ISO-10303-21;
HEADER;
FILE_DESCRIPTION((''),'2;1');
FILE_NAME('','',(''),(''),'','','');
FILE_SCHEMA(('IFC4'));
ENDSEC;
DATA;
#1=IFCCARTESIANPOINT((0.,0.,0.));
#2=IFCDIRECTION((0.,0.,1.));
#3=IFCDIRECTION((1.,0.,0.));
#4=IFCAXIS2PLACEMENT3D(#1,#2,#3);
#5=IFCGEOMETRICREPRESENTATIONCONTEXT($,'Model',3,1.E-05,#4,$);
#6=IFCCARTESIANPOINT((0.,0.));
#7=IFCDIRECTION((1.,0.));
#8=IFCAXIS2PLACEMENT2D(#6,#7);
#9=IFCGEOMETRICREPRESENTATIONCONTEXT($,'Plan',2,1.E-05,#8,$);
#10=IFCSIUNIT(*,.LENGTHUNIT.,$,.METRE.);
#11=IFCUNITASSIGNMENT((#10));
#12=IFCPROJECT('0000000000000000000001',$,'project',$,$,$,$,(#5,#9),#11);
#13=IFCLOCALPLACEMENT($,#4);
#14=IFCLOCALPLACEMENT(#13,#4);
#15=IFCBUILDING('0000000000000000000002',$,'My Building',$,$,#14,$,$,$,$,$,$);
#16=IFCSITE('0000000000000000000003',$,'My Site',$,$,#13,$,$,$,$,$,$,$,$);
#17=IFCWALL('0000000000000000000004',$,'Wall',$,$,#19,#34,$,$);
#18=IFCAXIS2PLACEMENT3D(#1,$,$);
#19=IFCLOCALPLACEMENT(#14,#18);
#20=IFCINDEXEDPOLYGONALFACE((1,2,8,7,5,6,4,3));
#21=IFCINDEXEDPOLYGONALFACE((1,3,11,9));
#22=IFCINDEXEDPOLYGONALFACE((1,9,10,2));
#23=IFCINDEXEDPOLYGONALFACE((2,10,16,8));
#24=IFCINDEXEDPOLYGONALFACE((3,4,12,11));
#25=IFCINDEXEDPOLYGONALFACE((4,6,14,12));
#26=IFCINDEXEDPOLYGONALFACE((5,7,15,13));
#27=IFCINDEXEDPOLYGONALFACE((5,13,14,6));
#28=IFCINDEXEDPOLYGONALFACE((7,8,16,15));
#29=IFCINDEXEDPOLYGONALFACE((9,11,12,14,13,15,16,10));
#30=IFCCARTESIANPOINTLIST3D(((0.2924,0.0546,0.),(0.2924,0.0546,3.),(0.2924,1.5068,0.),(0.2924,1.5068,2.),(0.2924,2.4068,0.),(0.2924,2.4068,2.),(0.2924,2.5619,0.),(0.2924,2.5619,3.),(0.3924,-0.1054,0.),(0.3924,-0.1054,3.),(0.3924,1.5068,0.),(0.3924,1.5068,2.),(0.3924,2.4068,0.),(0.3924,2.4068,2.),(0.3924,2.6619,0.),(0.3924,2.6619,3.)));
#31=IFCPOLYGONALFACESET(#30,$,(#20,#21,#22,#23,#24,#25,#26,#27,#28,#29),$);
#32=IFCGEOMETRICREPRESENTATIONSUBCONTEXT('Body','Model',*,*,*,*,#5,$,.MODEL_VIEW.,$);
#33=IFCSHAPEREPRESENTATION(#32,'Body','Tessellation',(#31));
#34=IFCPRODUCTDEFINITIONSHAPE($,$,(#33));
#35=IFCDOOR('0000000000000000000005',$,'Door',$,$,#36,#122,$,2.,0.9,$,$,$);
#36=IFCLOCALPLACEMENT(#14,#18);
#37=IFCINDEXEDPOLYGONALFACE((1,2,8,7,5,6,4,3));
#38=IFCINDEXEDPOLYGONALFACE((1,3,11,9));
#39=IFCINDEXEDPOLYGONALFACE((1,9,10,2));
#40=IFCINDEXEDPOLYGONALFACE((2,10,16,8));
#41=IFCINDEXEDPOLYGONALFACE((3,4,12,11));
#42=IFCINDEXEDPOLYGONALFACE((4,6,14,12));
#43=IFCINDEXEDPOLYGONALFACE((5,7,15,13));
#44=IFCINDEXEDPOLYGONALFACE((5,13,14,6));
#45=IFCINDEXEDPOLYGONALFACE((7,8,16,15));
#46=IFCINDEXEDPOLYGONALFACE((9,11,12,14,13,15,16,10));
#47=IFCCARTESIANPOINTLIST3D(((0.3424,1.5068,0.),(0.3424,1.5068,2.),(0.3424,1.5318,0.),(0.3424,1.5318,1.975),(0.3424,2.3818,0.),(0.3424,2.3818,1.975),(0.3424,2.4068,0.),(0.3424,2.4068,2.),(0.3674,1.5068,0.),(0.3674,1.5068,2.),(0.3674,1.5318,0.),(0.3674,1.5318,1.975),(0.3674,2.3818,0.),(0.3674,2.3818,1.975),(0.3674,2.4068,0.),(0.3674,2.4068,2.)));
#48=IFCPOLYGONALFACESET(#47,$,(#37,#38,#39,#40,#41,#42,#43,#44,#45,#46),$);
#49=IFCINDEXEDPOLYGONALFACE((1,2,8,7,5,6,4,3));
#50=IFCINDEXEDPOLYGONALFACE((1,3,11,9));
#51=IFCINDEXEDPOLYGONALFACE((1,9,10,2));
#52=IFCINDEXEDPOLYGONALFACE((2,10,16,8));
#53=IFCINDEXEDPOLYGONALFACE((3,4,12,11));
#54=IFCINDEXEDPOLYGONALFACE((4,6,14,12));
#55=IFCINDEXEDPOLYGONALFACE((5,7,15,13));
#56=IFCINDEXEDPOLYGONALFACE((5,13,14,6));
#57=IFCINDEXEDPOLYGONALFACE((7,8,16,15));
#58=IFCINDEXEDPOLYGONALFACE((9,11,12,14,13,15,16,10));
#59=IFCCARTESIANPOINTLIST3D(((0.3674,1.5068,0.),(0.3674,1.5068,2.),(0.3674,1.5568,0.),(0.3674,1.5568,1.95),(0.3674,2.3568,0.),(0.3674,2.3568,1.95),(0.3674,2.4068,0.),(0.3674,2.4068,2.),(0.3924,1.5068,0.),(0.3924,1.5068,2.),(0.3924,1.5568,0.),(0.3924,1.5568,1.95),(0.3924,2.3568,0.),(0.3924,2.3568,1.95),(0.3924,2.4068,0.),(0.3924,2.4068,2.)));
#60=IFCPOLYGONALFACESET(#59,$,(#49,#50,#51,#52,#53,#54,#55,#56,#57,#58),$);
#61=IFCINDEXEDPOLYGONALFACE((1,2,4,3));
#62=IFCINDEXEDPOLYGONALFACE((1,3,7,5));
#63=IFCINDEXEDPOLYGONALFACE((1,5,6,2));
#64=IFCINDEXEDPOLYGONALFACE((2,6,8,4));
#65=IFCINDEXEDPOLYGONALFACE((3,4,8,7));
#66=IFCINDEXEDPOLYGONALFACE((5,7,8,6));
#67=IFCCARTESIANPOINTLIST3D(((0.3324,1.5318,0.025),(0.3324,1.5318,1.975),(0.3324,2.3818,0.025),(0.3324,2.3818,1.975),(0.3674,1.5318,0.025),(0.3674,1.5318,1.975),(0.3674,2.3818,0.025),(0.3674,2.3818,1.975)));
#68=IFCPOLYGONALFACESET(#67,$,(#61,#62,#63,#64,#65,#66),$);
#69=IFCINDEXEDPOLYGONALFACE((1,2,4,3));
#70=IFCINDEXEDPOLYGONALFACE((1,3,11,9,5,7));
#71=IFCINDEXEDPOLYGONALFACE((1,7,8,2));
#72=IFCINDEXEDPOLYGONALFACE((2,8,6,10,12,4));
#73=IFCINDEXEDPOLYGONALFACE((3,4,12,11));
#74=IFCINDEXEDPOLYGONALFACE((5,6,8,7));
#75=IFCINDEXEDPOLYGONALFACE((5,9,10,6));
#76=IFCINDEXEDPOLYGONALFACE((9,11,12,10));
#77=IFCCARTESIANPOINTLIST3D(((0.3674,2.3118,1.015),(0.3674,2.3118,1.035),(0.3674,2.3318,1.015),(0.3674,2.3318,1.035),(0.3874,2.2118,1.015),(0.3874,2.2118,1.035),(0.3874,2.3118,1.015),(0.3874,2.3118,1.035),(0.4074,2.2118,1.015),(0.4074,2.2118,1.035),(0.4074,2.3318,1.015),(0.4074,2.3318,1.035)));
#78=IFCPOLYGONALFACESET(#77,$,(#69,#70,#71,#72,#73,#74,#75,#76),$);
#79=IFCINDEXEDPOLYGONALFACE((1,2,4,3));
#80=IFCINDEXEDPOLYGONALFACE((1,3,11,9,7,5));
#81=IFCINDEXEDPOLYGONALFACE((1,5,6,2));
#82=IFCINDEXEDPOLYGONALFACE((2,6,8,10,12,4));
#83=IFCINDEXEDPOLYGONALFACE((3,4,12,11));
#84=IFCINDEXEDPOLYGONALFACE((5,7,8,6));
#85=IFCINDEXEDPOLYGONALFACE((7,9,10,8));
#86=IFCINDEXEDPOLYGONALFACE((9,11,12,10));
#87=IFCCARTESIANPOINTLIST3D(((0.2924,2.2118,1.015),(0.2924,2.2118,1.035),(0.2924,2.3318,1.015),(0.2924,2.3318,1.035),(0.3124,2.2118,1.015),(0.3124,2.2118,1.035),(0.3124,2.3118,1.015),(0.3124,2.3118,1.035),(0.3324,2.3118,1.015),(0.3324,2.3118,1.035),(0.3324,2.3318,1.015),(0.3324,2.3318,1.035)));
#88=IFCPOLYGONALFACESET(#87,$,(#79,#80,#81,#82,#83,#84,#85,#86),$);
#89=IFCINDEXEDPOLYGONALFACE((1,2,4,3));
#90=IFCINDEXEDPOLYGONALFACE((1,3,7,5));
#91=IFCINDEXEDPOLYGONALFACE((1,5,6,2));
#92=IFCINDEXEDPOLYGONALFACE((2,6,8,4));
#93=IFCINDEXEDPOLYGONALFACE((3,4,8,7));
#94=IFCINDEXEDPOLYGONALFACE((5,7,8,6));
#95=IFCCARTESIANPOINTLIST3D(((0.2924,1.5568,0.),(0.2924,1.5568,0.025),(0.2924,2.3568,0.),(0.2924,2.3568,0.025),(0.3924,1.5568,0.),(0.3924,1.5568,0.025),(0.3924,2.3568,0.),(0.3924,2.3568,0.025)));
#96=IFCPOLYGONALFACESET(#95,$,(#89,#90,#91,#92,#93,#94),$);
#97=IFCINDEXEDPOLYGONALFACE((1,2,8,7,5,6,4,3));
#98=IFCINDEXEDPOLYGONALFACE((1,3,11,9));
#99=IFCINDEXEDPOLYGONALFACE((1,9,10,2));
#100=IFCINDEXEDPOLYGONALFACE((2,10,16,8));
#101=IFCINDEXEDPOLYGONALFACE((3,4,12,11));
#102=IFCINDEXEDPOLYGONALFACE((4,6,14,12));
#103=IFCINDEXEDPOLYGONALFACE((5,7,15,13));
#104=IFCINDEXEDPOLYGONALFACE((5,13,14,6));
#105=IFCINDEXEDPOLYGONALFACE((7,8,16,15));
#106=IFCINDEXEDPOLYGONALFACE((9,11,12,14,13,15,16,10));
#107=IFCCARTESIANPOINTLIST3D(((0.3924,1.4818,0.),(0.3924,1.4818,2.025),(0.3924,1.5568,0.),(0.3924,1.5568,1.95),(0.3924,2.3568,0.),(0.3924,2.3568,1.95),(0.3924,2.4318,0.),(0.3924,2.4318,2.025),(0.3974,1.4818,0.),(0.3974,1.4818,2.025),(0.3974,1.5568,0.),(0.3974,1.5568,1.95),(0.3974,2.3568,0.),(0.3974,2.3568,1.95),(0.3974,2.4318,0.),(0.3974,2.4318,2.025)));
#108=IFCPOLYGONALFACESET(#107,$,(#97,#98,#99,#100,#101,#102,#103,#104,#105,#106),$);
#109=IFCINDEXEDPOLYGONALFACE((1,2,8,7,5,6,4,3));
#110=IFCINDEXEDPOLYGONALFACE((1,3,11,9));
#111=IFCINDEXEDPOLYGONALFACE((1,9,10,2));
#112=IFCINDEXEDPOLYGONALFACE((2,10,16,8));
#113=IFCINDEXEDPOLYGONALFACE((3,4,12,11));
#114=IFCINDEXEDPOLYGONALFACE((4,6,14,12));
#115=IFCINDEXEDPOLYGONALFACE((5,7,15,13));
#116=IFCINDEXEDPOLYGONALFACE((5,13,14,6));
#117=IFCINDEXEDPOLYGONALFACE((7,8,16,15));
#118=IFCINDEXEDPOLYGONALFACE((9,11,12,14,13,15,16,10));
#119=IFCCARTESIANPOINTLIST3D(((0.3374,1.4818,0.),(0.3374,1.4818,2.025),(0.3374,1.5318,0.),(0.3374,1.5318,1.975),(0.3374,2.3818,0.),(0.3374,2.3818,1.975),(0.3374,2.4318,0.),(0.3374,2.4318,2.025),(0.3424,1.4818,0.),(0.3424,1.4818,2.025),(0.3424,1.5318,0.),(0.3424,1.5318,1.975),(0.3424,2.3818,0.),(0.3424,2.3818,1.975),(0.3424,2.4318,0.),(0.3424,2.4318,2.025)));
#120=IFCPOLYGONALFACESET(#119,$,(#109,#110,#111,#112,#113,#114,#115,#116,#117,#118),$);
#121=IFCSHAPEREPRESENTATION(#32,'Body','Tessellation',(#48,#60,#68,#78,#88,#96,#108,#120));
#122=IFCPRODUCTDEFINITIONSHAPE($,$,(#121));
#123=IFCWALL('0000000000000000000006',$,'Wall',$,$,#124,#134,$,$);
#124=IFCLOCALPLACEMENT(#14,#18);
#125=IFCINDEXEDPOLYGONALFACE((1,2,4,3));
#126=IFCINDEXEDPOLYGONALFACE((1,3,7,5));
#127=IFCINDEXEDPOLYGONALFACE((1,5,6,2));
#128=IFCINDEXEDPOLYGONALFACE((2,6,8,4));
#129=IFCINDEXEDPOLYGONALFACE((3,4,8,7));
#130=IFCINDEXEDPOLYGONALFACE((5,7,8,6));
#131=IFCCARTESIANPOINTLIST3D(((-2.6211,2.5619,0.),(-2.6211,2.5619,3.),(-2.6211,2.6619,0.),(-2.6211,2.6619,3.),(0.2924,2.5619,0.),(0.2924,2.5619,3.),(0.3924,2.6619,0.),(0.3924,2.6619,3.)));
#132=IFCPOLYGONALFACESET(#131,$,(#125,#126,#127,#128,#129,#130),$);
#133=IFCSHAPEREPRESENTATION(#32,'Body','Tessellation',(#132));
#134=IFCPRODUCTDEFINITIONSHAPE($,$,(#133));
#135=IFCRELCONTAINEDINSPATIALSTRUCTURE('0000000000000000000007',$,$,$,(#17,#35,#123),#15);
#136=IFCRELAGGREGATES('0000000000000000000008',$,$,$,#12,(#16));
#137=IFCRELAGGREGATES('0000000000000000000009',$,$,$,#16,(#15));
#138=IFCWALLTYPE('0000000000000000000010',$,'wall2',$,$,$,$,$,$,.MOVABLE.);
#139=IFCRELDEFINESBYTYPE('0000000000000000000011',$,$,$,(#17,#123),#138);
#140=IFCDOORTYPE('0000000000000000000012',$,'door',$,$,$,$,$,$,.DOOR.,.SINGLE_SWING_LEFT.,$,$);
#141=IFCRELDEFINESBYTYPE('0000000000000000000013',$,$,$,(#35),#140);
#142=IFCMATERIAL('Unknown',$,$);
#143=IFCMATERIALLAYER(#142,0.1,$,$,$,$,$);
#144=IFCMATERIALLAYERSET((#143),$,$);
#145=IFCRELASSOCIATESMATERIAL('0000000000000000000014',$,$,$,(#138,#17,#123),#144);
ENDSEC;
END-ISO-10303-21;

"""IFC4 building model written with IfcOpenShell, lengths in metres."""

from ifc_helpers import new_model, entity, si_unit, frame, origin_with_axes, origin_2d_with_axis, place, context, subcontext, project, spatial, line, indexed_curve, outline, extrude, shape, source, transform, mapped, material, layer, layer_set, layer_usage, type_object, type_shapes, element, fill, save


model = new_model("IFC4")

# Units and contexts
model_context = context("Model", 3, precision=1e-05, world=origin_with_axes())
plan_context = context("Plan", 2, precision=1e-05, world=origin_2d_with_axis())
body_context_1 = subcontext(model_context, "Body", "Model", "MODEL_VIEW")
body_context_2 = subcontext(plan_context, "Body", "Plan", "PLAN_VIEW")
ifc_project = project(units=[si_unit("LENGTHUNIT", "METRE")], contexts=[model_context, plan_context])

# Site, building
site_placement = place(None, origin_with_axes())
site = spatial("IfcSite", under=ifc_project, at=site_placement, Name="My Site")
building_placement = place(site_placement, origin_with_axes())
building = spatial("IfcBuilding", under=site, at=building_placement, Name="My Building")

# Shared definitions
ifc_material = material(Name="Unknown")

# Shared definitions
shared_shape_1 = source(origin_with_axes(), body_context_1, "Body", "SweptSolid", [
    extrude(outline(indexed_curve([(0.0, 0.0), (0.9, 0.0), (0.9, 2.0), (0.0, 2.0)], segments=[line(1, 2, 3, 4, 1)])), frame((0.0, -0.6, 0.0), z_axis=(0.0, -1.0, 0.0), x_axis=(1.0, 0.0, 0.0)), (0.0, 0.0, -1.0), 1.2),
])
door_type = type_object("IfcDoorType", Name="door", OperationType="SINGLE_SWING_LEFT", PredefinedType="DOOR")
shared_shape_2 = source(origin_with_axes(), body_context_1, "Body", "SweptSolid", [
    extrude(outline(indexed_curve([(0.0, 0.0), (0.0, 2.0), (0.9, 2.0), (0.9, 0.0), (0.875, 0.0), (0.875, 1.975), (0.025, 1.975), (0.025, 0.0)], segments=[line(1, 2, 3, 4, 5, 6, 7, 8, 1)])), frame((0.0, 0.025, 0.0), z_axis=(0.0, -1.0, 0.0), x_axis=(1.0, 0.0, 0.0)), (0.0, 0.0, -1.0), 0.025),
    extrude(outline(indexed_curve([(0.0, 0.0), (0.0, 2.0), (0.9, 2.0), (0.9, 0.0), (0.85, 0.0), (0.85, 1.95), (0.05, 1.95), (0.05, 0.0)], segments=[line(1, 2, 3, 4, 5, 6, 7, 8, 1)])), frame((0.0, 0.0, 0.0), z_axis=(0.0, -1.0, 0.0), x_axis=(1.0, 0.0, 0.0)), (0.0, 0.0, -1.0), 0.025),
    extrude(outline(indexed_curve([(0.0, 0.0), (0.85, 0.0), (0.85, 0.035), (0.0, 0.035)], segments=[line(1, 2, 3, 4, 1)])), frame((0.025, 0.025, 0.025), z_axis=(0.0, 0.0, 1.0), x_axis=(1.0, 0.0, 0.0)), (0.0, 0.0, 1.0), 1.95),
    extrude(outline(indexed_curve([(0.0, 0.0), (0.0, -0.04), (-0.12, -0.04), (-0.12, -0.02), (-0.02, -0.02), (-0.02, 0.0)], segments=[line(1, 2, 3, 4, 5, 6, 1)])), frame((0.825, 0.025, 1.015), z_axis=(0.0, 0.0, 1.0), x_axis=(1.0, 0.0, 0.0)), (0.0, 0.0, 1.0), 0.02),
    extrude(outline(indexed_curve([(0.0, 0.0), (0.0, 0.04), (-0.12, 0.04), (-0.12, 0.02), (-0.02, 0.02), (-0.02, 0.0)], segments=[line(1, 2, 3, 4, 5, 6, 1)])), frame((0.825, 0.06, 1.015), z_axis=(0.0, 0.0, 1.0), x_axis=(1.0, 0.0, 0.0)), (0.0, 0.0, 1.0), 0.02),
    extrude(outline(indexed_curve([(0.0, 0.0), (0.8, 0.0), (0.8, 0.1), (0.0, 0.1)], segments=[line(1, 2, 3, 4, 1)])), frame((0.05, 0.0, 0.0), z_axis=(0.0, 0.0, 1.0), x_axis=(1.0, 0.0, 0.0)), (0.0, 0.0, 1.0), 0.025),
    extrude(outline(indexed_curve([(0.0, 0.0), (0.0, 2.025), (0.95, 2.025), (0.95, 0.0), (0.875, 0.0), (0.875, 1.95), (0.075, 1.95), (0.075, 0.0)], segments=[line(1, 2, 3, 4, 5, 6, 7, 8, 1)])), frame((-0.025, -0.005, 0.0), z_axis=(0.0, -1.0, 0.0), x_axis=(1.0, 0.0, 0.0)), (0.0, 0.0, -1.0), 0.005),
    extrude(outline(indexed_curve([(0.0, 0.0), (0.0, 2.025), (0.95, 2.025), (0.95, 0.0), (0.9, 0.0), (0.9, 1.975), (0.05, 1.975), (0.05, 0.0)], segments=[line(1, 2, 3, 4, 5, 6, 7, 8, 1)])), frame((-0.025, 0.05, 0.0), z_axis=(0.0, -1.0, 0.0), x_axis=(1.0, 0.0, 0.0)), (0.0, 0.0, -1.0), 0.005),
])
shared_shape_3 = source(origin_with_axes(), body_context_2, "Body", "Curve2D", [
    entity("IfcIndexedPolyCurve", entity("IfcCartesianPointList2D", [[0.0, 0.0], [0.0, 0.05], [0.025, 0.05], [0.025, 0.025], [0.05, 0.025], [0.05, 0.0]]), [entity("IfcLineIndex", [1, 2, 3, 4, 5, 6, 1])]),
    entity("IfcIndexedPolyCurve", entity("IfcCartesianPointList2D", [[0.9, 0.0], [0.9, 0.05], [0.875, 0.05], [0.875, 0.025], [0.85, 0.025], [0.85, 0.0]]), [entity("IfcLineIndex", [1, 2, 3, 4, 5, 6, 1])]),
    entity("IfcTrimmedCurve", entity("IfcEllipse", entity("IfcAxis2Placement2D", entity("IfcCartesianPoint", [0.06, 0.05]), entity("IfcDirection", [1.0, 0.0])), 0.815, 0.85), [entity("IfcCartesianPoint", [0.875, 0.05])], [entity("IfcCartesianPoint", [0.06, 0.9])], True, "CARTESIAN"),
    entity("IfcIndexedPolyCurve", entity("IfcCartesianPointList2D", [[0.025, 0.05], [0.06, 0.05], [0.06, 0.9], [0.025, 0.9]]), [entity("IfcLineIndex", [1, 2, 3, 4, 1])]),
])
type_shapes(door_type, [shared_shape_2, shared_shape_3])

# Shared definitions
ifc_layer_1 = layer(ifc_material, 0.1)
ifc_layer_set_1 = layer_set([ifc_layer_1])
wall_type_1 = type_object("IfcWallType", Name="wall2", PredefinedType="MOVABLE", material=ifc_layer_set_1)

# Wall, opening, door
ifc_layer_usage_1 = layer_usage(ifc_layer_set_1, "AXIS2", "POSITIVE", 0.0)
wall_1_placement = place(building_placement, frame((0.3924, 0.0546, 0.0), z_axis=(0.0, 0.0, 1.0), x_axis=(0.0, 1.0, 0.0)))
wall_1 = element("IfcWall", 1, at=wall_1_placement, inside=building, type_object=wall_type_1, material=ifc_layer_usage_1, Name="Wall", context=body_context_1, shape_type="SweptSolid", body=[
    extrude(outline(indexed_curve([(-0.16, 0.0), (0.0, 0.1), (2.5074, 0.1), (2.6074, 0.0)], segments=[line(1, 2, 3, 4, 1)])), origin_with_axes(), (0.0, 0.0, 1.0), 3.0),
])
opening_1_placement = place(wall_1_placement, frame((1.4522, 0.0, 0.0), z_axis=(0.0, 0.0, 1.0), x_axis=(1.0, 0.0, 0.0)))
opening_1 = element("IfcOpeningElement", 2, at=opening_1_placement, cuts=wall_1, PredefinedType="OPENING", context=body_context_1, shape_type="MappedRepresentation", body=[
    mapped(shared_shape_1, transform((0.0, 0.0, 0.0), x_axis=(1.0, 0.0, 0.0), y_axis=(0.0, 1.0, 0.0), z_axis=(0.0, 0.0, 1.0), scale=1.0)),
])
door_1_placement = place(opening_1_placement, frame((0.0, 0.0, 0.0), z_axis=(0.0, 0.0, 1.0), x_axis=(1.0, 0.0, 0.0)))
door_1 = element("IfcDoor", 3, at=door_1_placement, inside=building, type_object=door_type, Name="Door", OverallHeight=2.0, OverallWidth=0.9, shapes=[
    shape(body_context_1, "Body", "MappedRepresentation", [mapped(shared_shape_2, transform((0.0, 0.0, 0.0), x_axis=(1.0, 0.0, 0.0), y_axis=(0.0, 1.0, 0.0), z_axis=(0.0, 0.0, 1.0), scale=1.0))]),
    shape(body_context_2, "Body", "MappedRepresentation", [mapped(shared_shape_3, transform((0.0, 0.0, 0.0), x_axis=(1.0, 0.0, 0.0), y_axis=(0.0, 1.0, 0.0), z_axis=(0.0, 0.0, 1.0), scale=1.0))]),
])
fill(opening_1, door_1)

# Wall
ifc_layer_usage_2 = layer_usage(ifc_layer_set_1, "AXIS2", "POSITIVE", 0.0)
wall_2_placement = place(building_placement, frame((0.3924, 2.6619, 0.0), z_axis=(0.0, 0.0, 1.0), x_axis=(-1.0, 0.0, 0.0)))
element("IfcWall", 4, at=wall_2_placement, inside=building, type_object=wall_type_1, material=ifc_layer_usage_2, Name="Wall", context=body_context_1, shape_type="SweptSolid", body=[
    extrude(outline(indexed_curve([(0.0, 0.0), (0.1, 0.1), (3.0135, 0.1), (3.0135, 0.0)], segments=[line(1, 2, 3, 4, 1)])), origin_with_axes(), (0.0, 0.0, 1.0), 3.0),
])

save(model, "model.ifc")
